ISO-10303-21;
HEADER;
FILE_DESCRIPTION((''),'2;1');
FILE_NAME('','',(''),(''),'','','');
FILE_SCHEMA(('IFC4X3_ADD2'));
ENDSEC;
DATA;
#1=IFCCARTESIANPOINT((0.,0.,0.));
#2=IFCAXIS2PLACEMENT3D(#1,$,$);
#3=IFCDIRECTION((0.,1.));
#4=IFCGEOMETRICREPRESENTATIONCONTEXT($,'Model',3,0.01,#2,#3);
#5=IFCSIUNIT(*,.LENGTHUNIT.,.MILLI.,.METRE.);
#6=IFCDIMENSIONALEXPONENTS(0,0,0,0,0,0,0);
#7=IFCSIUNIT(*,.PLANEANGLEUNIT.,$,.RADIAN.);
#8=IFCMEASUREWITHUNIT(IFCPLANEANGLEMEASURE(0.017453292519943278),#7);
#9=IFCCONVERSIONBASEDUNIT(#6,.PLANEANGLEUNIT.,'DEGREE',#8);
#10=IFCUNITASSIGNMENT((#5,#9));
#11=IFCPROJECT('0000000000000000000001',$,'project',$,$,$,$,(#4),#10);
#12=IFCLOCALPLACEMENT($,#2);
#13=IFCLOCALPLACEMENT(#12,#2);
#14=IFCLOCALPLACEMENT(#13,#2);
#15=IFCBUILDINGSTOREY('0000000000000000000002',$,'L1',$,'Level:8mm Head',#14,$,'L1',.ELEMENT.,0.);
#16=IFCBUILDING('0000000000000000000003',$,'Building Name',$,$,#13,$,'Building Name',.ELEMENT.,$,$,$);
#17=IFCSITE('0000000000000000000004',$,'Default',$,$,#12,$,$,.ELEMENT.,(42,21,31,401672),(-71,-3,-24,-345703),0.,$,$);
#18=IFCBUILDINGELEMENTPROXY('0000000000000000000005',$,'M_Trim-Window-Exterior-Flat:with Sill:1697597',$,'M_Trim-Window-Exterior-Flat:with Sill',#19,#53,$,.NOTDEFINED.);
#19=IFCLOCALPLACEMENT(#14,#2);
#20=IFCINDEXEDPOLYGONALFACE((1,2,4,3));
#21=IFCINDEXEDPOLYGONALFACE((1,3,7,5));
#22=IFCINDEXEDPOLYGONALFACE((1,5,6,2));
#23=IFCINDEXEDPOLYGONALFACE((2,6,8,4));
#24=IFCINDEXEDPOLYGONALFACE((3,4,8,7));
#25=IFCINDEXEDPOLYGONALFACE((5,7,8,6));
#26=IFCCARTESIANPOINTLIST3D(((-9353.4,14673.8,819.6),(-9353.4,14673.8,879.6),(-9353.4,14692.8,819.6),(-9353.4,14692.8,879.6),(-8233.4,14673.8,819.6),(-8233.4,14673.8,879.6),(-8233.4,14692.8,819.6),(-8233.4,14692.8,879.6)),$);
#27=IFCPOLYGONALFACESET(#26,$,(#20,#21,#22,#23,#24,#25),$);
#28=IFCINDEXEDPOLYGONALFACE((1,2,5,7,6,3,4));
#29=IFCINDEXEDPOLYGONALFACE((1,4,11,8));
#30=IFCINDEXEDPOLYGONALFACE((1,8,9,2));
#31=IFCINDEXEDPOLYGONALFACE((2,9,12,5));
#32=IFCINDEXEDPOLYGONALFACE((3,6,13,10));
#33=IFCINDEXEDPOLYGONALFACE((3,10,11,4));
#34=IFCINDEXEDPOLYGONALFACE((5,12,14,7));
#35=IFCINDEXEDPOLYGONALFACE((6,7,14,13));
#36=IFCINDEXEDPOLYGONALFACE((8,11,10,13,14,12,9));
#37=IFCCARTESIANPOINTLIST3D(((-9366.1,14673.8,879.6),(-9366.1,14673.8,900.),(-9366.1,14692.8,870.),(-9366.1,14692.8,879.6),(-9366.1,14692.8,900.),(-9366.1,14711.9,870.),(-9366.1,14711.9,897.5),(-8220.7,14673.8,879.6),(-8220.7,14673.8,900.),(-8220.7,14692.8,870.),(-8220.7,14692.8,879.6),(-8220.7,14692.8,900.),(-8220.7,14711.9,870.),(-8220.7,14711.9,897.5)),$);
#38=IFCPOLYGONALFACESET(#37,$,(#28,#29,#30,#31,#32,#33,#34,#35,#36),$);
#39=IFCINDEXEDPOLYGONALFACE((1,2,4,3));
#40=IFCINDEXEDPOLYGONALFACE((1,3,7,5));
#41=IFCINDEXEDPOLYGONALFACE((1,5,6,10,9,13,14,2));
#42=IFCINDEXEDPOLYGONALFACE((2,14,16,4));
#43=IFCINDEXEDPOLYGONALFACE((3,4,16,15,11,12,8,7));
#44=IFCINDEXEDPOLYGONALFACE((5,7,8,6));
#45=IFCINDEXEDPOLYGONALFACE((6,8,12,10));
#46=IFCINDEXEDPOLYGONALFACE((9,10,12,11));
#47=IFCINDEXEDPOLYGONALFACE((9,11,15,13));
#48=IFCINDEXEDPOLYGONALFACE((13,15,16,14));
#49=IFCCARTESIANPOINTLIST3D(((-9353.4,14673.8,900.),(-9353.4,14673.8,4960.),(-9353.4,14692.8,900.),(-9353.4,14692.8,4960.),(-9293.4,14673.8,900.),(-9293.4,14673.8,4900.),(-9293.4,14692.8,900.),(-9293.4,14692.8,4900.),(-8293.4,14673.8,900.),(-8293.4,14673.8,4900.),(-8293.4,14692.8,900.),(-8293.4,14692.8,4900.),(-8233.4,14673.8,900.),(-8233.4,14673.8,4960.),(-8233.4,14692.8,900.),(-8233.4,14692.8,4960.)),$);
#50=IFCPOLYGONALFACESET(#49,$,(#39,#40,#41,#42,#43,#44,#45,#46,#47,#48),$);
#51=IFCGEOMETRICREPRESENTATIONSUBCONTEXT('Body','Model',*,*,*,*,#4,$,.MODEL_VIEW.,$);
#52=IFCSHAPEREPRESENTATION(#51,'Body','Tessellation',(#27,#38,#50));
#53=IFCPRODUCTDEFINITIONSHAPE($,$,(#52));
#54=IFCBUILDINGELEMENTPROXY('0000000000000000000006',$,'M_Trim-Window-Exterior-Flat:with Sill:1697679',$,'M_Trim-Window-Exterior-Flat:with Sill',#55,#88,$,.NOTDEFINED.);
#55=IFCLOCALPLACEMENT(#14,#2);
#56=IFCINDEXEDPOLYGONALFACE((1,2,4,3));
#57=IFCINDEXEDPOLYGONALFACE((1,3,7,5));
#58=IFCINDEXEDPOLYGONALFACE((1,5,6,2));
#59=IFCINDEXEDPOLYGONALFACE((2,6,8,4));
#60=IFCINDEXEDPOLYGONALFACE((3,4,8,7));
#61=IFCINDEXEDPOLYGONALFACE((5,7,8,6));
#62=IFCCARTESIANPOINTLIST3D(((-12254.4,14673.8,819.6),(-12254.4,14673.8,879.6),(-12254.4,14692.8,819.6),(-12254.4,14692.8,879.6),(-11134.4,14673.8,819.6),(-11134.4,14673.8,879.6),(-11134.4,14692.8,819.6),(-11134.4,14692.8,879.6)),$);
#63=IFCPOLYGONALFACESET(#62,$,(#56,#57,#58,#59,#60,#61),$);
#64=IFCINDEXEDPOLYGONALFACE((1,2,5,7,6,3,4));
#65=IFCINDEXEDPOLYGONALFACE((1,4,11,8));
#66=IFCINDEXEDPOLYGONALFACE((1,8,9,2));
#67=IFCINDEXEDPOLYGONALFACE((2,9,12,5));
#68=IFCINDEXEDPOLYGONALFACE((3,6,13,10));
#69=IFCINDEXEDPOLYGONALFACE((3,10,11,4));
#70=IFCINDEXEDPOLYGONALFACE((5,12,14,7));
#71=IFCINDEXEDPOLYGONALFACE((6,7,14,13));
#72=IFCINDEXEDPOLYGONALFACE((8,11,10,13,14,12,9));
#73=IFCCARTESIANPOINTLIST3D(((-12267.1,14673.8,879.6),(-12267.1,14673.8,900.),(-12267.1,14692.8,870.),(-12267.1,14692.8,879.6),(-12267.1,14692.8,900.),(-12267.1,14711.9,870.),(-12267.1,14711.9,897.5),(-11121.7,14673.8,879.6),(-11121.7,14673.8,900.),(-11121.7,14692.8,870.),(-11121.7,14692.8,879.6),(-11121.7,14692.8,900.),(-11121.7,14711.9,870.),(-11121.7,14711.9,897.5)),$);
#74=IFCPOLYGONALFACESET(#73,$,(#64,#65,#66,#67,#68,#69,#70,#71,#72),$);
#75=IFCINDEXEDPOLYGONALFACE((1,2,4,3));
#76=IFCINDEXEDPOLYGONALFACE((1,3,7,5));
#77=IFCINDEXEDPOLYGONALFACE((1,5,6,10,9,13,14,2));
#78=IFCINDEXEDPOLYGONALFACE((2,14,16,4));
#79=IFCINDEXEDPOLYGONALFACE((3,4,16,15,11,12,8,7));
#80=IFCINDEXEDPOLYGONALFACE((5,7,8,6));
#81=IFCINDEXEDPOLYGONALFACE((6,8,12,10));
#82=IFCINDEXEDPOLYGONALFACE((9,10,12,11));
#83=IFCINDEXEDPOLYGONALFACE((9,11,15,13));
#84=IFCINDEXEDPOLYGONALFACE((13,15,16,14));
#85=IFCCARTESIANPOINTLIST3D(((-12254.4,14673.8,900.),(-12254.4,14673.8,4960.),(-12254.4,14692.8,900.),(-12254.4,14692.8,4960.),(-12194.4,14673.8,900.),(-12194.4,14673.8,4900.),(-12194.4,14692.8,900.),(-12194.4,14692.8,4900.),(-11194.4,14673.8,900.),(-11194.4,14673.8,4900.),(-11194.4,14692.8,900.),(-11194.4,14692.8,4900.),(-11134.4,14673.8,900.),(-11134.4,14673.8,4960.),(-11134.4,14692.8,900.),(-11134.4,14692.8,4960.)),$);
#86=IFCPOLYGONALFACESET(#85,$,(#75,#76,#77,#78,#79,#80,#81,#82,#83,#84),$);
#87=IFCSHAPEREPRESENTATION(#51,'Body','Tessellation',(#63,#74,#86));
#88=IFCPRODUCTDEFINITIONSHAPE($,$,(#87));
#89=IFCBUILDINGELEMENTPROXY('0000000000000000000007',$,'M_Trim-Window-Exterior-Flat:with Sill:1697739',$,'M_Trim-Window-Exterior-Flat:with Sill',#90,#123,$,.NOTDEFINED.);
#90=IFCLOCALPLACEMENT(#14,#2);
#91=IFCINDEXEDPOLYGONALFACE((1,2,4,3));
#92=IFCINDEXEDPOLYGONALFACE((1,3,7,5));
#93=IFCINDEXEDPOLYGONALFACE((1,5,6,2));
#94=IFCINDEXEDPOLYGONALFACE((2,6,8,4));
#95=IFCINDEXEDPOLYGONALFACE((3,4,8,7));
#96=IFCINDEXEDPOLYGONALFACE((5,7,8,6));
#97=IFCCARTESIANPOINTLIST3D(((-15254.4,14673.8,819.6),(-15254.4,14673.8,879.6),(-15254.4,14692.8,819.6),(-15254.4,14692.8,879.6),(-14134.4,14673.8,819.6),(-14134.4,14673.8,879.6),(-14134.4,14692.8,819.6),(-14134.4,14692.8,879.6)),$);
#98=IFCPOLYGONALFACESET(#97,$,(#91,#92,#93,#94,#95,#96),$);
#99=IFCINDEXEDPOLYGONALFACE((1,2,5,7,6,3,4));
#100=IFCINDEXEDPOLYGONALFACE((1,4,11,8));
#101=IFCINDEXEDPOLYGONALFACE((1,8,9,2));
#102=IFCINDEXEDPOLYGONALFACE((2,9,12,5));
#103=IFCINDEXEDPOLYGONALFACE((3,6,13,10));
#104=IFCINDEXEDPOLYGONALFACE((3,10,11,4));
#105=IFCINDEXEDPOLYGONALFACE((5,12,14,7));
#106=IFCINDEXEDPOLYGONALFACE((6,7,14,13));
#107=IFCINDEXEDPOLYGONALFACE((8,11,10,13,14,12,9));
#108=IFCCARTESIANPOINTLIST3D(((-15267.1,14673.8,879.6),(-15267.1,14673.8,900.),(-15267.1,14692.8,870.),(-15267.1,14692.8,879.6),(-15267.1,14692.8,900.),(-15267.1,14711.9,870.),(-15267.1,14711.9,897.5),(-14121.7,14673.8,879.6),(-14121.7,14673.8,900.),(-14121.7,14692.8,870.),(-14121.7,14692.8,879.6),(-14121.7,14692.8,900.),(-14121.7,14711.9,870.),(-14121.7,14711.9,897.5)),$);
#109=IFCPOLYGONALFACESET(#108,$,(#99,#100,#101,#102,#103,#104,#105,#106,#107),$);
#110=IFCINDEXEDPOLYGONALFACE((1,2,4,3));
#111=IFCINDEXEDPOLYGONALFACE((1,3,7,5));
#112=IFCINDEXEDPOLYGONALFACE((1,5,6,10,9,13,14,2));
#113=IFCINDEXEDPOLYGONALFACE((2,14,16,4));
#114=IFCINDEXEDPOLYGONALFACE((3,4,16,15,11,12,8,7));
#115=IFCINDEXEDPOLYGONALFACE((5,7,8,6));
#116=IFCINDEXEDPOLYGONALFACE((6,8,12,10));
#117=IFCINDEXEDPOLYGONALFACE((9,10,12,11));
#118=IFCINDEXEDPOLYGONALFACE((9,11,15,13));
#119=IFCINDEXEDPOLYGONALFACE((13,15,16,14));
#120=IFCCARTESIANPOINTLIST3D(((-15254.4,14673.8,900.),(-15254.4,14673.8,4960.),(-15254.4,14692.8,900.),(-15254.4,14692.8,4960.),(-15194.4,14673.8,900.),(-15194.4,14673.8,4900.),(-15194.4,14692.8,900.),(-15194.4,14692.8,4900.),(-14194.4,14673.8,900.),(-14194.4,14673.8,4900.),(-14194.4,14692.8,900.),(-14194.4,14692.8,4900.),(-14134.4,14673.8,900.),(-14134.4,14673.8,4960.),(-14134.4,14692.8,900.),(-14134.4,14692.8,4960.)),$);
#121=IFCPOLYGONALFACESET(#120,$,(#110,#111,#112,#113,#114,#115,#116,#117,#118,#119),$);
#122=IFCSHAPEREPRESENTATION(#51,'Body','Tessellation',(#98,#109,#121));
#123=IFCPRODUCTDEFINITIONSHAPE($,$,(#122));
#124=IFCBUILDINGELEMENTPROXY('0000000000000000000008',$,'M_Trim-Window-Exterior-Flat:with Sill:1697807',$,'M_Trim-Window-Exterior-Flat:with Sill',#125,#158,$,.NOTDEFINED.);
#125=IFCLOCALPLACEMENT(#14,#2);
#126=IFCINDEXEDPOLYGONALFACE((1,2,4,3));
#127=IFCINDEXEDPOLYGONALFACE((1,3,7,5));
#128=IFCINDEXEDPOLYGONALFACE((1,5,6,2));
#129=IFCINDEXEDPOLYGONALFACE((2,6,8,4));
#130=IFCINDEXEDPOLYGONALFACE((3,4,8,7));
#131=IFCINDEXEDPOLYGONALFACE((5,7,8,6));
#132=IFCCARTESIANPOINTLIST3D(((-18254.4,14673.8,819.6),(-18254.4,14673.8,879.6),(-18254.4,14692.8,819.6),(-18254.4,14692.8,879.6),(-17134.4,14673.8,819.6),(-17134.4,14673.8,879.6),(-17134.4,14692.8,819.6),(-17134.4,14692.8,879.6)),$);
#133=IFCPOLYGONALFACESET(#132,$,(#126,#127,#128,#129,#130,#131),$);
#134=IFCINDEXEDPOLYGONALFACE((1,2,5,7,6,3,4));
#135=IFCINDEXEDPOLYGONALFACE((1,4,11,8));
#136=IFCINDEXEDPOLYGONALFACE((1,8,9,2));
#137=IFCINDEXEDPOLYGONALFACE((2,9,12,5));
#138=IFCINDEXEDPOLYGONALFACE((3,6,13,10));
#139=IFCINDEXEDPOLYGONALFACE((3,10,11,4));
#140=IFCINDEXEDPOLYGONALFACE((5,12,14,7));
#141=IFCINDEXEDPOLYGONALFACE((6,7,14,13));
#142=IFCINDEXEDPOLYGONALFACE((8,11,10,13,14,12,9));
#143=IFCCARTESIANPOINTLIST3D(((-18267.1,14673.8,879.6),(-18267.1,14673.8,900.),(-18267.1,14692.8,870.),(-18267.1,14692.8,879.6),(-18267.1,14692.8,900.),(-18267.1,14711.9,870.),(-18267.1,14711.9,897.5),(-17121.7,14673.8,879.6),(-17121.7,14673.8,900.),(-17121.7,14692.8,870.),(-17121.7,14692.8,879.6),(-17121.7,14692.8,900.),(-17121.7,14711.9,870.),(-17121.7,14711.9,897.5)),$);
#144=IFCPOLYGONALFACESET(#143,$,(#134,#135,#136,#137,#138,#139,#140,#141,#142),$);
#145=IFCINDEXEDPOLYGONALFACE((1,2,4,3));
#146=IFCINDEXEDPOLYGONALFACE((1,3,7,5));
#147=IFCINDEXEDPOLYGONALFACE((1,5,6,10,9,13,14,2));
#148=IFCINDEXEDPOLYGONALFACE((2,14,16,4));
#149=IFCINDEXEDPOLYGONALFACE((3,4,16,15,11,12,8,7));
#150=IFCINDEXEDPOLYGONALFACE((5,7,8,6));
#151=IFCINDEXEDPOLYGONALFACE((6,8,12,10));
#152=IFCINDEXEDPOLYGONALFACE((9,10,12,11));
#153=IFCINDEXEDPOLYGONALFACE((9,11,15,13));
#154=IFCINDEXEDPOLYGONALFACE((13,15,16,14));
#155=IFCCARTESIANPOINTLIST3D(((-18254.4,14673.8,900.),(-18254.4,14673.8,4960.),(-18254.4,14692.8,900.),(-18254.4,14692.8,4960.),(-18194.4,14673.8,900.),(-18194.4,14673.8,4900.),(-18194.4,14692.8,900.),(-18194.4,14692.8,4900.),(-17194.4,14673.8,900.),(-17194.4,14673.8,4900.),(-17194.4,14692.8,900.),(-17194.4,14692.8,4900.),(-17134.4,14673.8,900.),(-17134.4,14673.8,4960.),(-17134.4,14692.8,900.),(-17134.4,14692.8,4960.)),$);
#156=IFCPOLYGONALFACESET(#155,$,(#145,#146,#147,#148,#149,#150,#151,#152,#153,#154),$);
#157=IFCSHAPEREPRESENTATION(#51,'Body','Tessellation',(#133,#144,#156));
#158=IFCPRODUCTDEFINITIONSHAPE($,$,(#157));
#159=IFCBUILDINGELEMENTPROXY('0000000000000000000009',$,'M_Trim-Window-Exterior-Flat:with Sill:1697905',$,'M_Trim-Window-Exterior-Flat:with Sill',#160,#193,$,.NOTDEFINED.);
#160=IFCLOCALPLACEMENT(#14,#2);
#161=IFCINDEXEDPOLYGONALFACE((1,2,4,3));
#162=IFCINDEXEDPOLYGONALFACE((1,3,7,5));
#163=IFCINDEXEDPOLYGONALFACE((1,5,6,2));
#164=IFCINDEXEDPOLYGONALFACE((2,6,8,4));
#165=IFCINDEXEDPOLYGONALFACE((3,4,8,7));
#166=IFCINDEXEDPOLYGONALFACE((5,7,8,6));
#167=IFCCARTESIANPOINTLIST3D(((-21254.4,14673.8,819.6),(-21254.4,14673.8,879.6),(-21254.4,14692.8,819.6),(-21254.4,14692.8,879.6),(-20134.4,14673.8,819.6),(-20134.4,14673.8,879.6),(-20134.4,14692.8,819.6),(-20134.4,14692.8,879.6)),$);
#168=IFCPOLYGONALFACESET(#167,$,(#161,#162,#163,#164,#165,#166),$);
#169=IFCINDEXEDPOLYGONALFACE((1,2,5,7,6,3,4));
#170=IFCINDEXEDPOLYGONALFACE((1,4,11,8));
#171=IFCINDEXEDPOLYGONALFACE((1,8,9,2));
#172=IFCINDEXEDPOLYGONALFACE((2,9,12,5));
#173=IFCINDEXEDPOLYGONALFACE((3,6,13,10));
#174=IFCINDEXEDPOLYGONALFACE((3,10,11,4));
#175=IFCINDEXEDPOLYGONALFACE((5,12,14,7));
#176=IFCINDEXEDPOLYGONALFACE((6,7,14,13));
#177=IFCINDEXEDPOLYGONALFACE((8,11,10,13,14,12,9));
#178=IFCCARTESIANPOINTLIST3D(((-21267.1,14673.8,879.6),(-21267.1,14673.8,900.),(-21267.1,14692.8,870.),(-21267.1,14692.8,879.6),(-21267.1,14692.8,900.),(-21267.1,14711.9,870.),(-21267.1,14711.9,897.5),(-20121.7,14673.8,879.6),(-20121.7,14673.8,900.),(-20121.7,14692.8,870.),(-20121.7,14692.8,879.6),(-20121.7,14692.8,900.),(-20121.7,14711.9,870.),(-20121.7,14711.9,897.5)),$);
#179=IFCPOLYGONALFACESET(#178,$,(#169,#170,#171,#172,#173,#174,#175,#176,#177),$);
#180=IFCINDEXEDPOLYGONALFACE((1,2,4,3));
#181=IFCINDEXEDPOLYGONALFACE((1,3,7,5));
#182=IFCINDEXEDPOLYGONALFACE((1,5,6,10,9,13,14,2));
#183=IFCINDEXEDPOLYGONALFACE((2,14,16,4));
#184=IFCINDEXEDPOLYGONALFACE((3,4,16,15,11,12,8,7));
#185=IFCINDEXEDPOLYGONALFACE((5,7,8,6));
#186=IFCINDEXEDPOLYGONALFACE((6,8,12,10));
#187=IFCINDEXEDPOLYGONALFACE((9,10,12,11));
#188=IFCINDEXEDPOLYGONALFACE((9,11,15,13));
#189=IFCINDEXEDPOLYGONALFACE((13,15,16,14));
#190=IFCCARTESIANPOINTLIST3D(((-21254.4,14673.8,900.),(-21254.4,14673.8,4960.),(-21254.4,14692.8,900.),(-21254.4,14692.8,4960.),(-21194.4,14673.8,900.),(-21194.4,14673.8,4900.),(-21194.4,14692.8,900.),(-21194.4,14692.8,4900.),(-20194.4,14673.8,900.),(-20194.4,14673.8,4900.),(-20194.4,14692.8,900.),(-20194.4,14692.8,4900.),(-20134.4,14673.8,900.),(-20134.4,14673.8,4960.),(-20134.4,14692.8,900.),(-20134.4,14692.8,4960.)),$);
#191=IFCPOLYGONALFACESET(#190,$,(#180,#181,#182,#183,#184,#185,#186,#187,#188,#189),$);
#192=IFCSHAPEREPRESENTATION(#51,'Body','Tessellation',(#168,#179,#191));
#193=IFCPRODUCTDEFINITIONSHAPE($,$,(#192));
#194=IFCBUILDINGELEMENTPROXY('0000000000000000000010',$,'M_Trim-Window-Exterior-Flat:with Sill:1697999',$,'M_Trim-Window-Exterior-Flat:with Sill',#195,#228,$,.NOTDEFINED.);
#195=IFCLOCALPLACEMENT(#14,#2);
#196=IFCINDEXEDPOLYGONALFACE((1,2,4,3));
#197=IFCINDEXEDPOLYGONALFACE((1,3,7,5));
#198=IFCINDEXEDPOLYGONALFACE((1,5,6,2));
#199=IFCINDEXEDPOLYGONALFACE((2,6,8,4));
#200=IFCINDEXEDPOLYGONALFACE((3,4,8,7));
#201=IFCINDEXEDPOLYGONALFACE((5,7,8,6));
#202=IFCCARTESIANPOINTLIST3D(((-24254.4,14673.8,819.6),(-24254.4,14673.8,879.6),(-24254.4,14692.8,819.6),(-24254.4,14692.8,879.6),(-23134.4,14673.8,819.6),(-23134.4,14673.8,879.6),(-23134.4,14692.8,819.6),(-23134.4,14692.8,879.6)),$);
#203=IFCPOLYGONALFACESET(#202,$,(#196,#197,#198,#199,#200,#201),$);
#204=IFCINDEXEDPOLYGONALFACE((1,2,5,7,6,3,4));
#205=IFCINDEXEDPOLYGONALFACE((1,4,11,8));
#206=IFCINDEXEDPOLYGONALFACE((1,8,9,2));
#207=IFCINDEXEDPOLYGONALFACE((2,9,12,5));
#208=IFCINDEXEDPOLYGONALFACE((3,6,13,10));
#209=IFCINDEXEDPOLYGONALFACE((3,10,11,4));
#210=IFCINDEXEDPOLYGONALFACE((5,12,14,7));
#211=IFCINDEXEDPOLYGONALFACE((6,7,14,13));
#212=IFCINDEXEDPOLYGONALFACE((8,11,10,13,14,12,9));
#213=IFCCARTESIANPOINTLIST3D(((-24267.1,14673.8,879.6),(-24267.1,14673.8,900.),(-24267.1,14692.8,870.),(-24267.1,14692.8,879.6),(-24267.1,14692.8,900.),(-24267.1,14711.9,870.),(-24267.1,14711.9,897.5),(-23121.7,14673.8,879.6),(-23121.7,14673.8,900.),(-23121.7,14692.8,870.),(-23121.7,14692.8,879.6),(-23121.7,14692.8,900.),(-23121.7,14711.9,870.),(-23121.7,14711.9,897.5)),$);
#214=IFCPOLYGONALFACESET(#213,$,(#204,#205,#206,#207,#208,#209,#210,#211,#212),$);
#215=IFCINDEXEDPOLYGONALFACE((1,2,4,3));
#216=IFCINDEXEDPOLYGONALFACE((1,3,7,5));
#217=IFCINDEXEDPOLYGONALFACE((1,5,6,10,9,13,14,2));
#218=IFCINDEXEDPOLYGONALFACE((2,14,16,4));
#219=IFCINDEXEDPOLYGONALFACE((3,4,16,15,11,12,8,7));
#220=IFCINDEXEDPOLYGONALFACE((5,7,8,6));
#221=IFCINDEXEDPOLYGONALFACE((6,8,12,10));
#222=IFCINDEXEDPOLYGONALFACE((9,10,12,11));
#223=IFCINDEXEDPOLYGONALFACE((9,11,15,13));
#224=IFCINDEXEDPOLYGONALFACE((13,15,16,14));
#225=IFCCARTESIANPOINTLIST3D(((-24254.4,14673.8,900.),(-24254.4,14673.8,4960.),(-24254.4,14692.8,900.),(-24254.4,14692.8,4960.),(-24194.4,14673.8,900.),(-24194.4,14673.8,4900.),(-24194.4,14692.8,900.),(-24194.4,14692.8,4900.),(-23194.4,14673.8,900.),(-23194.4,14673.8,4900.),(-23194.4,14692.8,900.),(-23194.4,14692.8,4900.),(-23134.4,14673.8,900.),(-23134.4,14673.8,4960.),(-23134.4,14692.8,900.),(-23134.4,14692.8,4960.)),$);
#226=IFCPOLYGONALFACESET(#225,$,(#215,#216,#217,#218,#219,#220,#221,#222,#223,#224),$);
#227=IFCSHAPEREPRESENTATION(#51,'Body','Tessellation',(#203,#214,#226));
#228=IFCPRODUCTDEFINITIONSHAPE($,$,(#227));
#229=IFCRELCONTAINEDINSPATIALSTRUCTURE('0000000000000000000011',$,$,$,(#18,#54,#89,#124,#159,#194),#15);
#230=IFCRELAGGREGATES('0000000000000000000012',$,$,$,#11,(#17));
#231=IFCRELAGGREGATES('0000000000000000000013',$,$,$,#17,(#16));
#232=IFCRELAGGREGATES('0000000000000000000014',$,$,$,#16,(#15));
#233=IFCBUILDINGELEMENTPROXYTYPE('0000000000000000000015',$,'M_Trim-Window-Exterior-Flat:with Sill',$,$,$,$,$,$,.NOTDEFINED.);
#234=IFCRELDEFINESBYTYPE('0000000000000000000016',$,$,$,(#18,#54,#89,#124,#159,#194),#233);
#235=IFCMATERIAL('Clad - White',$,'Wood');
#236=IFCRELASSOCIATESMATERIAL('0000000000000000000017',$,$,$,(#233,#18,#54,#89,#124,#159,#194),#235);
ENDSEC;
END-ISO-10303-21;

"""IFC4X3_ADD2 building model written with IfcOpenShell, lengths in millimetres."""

from ifc_helpers import new_model, entity, si_unit, converted_unit, direction, frame, frame_2d, origin, place, context, subcontext, project, spatial, polyline, rectangle, outline, extrude, source, transform, mapped, material, type_object, type_shapes, element, save


model = new_model("IFC4X3_ADD2")

# Units and contexts
model_context = context("Model", 3, precision=0.01, world=origin(), true_north=direction((0.0, 1.0)))
body_context = subcontext(model_context, "Body", "Model", "MODEL_VIEW")
ifc_project = project(units=[si_unit("LENGTHUNIT", "METRE", prefix="MILLI"), converted_unit("PLANEANGLEUNIT", "DEGREE", entity("IfcPlaneAngleMeasure", 0.017453292519943278), si_unit("PLANEANGLEUNIT", "RADIAN"), dimensions=[0, 0, 0, 0, 0, 0, 0])], contexts=[model_context])

# Site, building, storey
site_placement = place(None, origin())
site = spatial("IfcSite", under=ifc_project, at=site_placement, Name="Default", CompositionType="ELEMENT", RefLatitude=(42, 21, 31, 401672), RefLongitude=(-71, -3, -24, -345703), RefElevation=0.0)
building_placement = place(site_placement, origin())
building = spatial("IfcBuilding", under=site, at=building_placement, Name="Building Name", LongName="Building Name", CompositionType="ELEMENT")
storey_placement = place(building_placement, origin())
storey = spatial("IfcBuildingStorey", under=building, at=storey_placement, Name="L1", ObjectType="Level:8mm Head", LongName="L1", CompositionType="ELEMENT", Elevation=0.0)

# Building element proxies
ifc_material_1 = material(Name="Clad - White", Category="Wood")
building_element_proxy_type_1 = type_object("IfcBuildingElementProxyType", Name="M_Trim-Window-Exterior-Flat:with Sill", PredefinedType="NOTDEFINED", material=ifc_material_1)
shared_shape_1 = source(origin(), body_context, "Body", "SweptSolid", [
    extrude(rectangle(XDim=1120.0, YDim=60.0, at=frame_2d((0.0, 0.0), x_axis=(1.0, 0.0))), frame((0.0, -4050.4, 0.0), z_axis=(0.0, 0.0, 1.0), x_axis=(-1.0, 0.0, 0.0)), (0.0, 0.0, 1.0), 19.0),
    extrude(outline(polyline([(-19.0, -15.2), (0.0, -15.2), (0.0, -5.7), (19.0, -5.7), (19.0, 14.8), (0.0, 14.8), (-19.0, 12.3), (-19.0, -15.2)])), frame((-572.7, -4014.8, 19.0), z_axis=(1.0, 0.0, 0.0), x_axis=(0.0, 0.0, -1.0)), (0.0, 0.0, 1.0), 1145.4),
    extrude(outline(polyline([(-2045.0, -560.0), (2015.0, -560.0), (2015.0, -500.0), (-1985.0, -500.0), (-1985.0, 500.0), (2015.0, 500.0), (2015.0, 560.0), (-2045.0, 560.0), (-2045.0, -560.0)])), frame((0.0, -1985.0, 0.0), z_axis=(0.0, 0.0, 1.0), x_axis=(0.0, -1.0, 0.0)), (0.0, 0.0, 1.0), 19.0),
])
type_shapes(building_element_proxy_type_1, [shared_shape_1])
for number, where, z_axis, x_axis, name in (
    (1, (-8793.4, 14673.8, 4900.0), (0.0, 1.0, 0.0), (-1.0, 0.0, 0.0), "M_Trim-Window-Exterior-Flat:with Sill:1697597"),
    (2, (-11694.4, 14673.8, 4900.0), (0.0, 1.0, 0.0), (-1.0, 0.0, 0.0), "M_Trim-Window-Exterior-Flat:with Sill:1697679"),
    (3, (-14694.4, 14673.8, 4900.0), (0.0, 1.0, 0.0), (-1.0, 0.0, 0.0), "M_Trim-Window-Exterior-Flat:with Sill:1697739"),
    (4, (-17694.4, 14673.8, 4900.0), (0.0, 1.0, 0.0), (-1.0, 0.0, 0.0), "M_Trim-Window-Exterior-Flat:with Sill:1697807"),
    (5, (-20694.4, 14673.8, 4900.0), (0.0, 1.0, 0.0), (-1.0, 0.0, 0.0), "M_Trim-Window-Exterior-Flat:with Sill:1697905"),
    (6, (-23694.4, 14673.8, 4900.0), (0.0, 1.0, 0.0), (-1.0, 0.0, 0.0), "M_Trim-Window-Exterior-Flat:with Sill:1697999"),
):
    element("IfcBuildingElementProxy", number, at=place(storey_placement, frame(where, z_axis=z_axis, x_axis=x_axis)), inside=storey, type_object=building_element_proxy_type_1, material=ifc_material_1, Name=name, ObjectType="M_Trim-Window-Exterior-Flat:with Sill", PredefinedType="NOTDEFINED", context=body_context, shape_type="MappedRepresentation", body=[
        mapped(shared_shape_1, transform((0.0, 0.0, 0.0), scale=1.0)),
    ])

save(model, "model.ifc")
